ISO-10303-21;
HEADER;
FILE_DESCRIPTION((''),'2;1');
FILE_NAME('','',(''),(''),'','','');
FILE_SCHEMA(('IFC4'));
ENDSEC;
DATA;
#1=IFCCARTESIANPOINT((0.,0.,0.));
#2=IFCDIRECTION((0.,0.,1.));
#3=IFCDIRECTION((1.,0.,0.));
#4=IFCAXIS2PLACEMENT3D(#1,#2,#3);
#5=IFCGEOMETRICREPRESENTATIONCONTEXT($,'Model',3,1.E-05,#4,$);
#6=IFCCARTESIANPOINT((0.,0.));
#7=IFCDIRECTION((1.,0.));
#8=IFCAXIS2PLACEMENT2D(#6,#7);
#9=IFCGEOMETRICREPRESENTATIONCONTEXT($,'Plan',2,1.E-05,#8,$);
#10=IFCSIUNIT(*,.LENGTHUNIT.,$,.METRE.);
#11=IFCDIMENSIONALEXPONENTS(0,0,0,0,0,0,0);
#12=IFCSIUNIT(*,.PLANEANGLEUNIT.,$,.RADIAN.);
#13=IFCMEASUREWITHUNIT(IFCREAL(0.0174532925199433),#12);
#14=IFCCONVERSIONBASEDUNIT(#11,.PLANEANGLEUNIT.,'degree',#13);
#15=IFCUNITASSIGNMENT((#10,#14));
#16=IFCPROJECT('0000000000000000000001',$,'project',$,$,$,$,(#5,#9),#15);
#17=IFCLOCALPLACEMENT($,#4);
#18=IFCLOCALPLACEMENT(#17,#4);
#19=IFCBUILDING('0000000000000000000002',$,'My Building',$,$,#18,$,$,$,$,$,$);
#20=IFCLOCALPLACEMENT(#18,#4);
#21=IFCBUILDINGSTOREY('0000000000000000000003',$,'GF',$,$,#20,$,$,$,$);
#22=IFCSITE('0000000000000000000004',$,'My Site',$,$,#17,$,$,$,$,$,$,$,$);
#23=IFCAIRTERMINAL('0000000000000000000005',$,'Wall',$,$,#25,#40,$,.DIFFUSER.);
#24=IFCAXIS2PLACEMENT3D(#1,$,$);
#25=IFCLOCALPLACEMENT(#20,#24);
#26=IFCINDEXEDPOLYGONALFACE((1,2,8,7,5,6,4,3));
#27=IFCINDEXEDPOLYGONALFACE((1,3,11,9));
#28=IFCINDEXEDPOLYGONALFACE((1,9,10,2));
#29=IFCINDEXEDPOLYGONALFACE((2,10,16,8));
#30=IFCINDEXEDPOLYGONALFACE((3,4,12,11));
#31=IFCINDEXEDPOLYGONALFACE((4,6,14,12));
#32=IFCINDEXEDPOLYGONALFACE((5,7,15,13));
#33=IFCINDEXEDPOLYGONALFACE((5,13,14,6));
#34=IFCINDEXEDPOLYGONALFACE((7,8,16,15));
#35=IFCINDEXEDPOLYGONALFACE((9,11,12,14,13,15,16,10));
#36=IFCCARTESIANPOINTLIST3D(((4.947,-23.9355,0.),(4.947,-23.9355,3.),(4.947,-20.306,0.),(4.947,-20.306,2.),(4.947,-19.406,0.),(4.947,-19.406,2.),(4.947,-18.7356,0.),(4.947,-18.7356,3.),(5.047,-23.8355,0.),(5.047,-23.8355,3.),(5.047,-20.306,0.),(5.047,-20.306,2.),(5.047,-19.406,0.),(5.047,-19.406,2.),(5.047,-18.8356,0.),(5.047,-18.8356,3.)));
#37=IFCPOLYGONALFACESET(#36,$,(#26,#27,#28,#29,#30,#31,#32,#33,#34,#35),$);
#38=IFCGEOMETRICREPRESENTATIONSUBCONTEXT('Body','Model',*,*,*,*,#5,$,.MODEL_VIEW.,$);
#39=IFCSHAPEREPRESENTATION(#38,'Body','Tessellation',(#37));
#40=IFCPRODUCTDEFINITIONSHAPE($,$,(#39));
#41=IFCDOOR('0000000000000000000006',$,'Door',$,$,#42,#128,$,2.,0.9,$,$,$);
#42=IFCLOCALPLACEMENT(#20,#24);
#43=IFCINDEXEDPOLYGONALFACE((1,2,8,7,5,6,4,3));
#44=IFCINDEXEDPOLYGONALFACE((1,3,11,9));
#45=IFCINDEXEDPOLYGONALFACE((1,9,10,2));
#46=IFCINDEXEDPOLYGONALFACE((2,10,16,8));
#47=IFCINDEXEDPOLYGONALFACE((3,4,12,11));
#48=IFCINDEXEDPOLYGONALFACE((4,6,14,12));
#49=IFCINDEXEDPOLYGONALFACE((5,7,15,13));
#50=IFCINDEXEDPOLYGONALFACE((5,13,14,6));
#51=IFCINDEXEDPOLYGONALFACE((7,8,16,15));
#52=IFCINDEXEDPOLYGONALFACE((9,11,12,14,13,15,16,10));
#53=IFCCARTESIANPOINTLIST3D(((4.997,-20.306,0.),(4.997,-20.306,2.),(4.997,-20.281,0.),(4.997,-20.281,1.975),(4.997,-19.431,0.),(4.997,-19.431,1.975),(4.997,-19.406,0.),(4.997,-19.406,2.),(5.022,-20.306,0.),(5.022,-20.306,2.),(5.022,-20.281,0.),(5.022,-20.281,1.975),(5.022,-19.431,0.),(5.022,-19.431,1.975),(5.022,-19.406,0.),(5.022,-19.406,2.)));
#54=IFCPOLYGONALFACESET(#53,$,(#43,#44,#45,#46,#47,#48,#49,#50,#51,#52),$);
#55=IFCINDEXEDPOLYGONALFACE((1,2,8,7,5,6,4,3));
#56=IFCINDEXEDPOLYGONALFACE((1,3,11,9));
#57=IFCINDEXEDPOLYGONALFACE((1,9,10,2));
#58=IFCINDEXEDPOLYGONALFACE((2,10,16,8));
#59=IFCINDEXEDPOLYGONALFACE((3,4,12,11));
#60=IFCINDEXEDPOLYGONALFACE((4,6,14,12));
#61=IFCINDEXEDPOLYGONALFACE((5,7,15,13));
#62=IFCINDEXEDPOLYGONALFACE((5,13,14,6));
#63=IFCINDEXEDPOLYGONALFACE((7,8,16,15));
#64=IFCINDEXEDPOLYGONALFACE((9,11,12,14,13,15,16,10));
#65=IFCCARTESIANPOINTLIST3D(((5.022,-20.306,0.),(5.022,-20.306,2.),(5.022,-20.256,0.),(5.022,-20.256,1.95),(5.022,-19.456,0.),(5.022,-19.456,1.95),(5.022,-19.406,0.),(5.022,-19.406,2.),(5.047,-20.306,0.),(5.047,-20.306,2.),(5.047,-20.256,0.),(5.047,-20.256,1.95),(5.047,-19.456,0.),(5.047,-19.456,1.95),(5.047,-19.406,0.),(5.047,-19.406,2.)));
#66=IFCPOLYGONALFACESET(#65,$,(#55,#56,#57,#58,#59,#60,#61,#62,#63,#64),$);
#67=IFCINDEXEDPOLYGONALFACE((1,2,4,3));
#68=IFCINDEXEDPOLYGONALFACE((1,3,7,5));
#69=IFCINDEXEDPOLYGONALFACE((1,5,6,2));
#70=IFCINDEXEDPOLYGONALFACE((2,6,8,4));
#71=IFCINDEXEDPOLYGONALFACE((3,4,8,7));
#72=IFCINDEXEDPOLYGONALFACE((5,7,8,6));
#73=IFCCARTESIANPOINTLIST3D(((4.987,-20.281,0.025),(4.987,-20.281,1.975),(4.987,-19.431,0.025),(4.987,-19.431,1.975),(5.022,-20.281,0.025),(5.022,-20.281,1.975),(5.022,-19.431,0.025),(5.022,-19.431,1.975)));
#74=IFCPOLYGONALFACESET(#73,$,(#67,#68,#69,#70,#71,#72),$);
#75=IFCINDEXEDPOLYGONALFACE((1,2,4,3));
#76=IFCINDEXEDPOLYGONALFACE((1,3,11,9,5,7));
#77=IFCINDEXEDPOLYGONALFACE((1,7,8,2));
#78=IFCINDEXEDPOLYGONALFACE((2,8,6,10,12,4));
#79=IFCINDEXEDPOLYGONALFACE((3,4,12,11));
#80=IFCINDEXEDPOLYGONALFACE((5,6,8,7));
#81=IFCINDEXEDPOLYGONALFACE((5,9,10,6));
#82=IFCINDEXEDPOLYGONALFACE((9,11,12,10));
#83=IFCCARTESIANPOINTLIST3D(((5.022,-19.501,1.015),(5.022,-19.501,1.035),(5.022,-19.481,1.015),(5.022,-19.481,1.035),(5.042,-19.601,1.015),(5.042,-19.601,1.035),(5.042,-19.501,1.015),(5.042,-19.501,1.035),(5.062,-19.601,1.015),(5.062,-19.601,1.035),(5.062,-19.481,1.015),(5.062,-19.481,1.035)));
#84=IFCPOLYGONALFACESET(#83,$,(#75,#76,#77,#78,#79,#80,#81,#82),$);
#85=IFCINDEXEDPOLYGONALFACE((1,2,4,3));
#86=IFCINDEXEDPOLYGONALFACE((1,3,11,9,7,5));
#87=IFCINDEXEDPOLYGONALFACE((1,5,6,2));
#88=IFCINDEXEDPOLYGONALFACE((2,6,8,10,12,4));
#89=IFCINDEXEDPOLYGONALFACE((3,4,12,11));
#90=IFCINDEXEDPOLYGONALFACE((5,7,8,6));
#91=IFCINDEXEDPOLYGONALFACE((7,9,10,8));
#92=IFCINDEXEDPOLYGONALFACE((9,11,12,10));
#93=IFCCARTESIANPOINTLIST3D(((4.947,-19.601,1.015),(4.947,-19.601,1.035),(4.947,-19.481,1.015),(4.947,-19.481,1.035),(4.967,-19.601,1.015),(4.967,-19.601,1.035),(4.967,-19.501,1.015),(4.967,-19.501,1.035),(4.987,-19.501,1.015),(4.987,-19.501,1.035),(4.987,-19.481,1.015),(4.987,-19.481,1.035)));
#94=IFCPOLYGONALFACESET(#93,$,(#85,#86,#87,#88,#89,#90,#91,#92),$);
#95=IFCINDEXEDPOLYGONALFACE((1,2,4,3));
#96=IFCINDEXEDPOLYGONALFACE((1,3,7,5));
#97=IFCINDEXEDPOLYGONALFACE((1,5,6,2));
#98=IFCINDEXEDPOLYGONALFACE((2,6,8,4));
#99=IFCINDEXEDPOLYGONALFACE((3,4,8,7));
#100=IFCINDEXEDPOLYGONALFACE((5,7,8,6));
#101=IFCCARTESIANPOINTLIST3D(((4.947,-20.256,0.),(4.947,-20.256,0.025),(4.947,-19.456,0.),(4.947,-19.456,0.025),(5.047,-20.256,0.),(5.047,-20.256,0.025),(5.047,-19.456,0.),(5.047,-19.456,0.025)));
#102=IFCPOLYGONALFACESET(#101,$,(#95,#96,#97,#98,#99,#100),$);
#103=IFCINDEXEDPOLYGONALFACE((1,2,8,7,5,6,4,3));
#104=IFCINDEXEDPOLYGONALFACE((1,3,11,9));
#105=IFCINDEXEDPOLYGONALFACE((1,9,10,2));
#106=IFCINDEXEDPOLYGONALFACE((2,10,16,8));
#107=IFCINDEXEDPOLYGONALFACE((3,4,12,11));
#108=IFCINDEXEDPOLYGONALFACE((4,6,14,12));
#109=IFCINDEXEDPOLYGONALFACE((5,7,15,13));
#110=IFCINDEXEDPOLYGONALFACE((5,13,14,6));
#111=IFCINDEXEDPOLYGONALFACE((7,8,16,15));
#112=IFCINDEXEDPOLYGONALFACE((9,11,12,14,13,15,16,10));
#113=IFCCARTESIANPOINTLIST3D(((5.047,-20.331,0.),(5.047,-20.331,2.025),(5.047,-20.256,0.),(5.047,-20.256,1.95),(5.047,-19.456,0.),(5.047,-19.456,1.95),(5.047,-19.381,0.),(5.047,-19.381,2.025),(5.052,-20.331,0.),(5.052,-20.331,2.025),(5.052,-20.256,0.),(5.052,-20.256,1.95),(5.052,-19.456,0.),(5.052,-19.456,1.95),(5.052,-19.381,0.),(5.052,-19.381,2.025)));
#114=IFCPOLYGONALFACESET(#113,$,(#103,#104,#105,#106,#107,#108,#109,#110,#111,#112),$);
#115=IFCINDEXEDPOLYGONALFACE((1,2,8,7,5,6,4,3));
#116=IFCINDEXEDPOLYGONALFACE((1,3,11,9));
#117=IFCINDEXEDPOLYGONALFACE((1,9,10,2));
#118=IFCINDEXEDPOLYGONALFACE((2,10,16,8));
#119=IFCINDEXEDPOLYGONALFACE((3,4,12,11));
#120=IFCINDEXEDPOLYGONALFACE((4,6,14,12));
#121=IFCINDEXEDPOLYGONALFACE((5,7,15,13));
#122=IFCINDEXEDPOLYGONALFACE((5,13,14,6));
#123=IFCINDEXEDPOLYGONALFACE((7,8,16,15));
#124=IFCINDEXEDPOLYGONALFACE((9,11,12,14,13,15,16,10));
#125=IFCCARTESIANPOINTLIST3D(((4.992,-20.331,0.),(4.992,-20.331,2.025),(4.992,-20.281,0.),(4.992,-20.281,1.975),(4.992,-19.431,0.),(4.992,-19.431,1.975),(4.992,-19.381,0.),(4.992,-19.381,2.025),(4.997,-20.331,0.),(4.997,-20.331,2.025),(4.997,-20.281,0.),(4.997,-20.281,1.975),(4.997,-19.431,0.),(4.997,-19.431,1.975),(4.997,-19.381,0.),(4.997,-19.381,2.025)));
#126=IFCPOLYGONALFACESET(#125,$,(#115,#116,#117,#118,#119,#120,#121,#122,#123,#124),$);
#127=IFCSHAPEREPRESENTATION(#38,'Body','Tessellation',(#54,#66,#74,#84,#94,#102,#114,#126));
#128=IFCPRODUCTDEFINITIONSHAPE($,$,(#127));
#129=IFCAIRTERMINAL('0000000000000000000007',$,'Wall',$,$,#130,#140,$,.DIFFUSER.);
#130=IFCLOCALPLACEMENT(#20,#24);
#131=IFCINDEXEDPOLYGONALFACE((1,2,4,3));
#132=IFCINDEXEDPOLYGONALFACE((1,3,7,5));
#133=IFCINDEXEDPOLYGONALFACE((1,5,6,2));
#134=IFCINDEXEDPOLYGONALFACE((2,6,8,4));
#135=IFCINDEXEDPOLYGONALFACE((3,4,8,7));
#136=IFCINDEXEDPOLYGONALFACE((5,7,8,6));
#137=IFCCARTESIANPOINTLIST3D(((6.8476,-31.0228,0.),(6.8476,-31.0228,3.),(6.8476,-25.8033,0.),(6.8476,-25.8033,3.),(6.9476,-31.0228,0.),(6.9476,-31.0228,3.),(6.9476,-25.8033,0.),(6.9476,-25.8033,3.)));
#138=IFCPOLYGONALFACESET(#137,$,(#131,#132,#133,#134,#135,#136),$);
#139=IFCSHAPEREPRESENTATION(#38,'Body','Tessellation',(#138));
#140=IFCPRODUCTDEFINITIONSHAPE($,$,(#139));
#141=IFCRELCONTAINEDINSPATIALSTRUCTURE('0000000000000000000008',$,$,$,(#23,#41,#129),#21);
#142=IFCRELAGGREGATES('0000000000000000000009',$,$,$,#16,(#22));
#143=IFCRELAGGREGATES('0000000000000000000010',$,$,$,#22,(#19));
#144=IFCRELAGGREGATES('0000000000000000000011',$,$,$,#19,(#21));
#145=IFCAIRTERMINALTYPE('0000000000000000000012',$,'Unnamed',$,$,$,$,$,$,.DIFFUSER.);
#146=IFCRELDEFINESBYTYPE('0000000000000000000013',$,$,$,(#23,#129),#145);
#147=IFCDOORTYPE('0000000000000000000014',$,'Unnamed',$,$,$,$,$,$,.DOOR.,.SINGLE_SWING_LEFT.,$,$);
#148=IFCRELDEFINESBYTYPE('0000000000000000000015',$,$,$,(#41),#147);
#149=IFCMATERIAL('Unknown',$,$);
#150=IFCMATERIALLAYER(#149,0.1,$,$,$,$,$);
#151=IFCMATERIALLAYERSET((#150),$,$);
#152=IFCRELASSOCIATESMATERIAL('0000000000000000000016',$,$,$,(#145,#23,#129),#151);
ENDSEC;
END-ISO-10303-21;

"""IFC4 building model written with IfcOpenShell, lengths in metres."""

from ifc_helpers import new_model, entity, si_unit, converted_unit, frame, origin_with_axes, origin_2d_with_axis, place, context, subcontext, project, spatial, line, indexed_curve, outline, extrude, shape, source, transform, mapped, material, layer, layer_set, layer_usage, type_object, type_shapes, element, fill, save


model = new_model("IFC4")

# Units and contexts
model_context = context("Model", 3, precision=1e-05, world=origin_with_axes())
plan_context = context("Plan", 2, precision=1e-05, world=origin_2d_with_axis())
body_context_1 = subcontext(model_context, "Body", "Model", "MODEL_VIEW")
body_context_2 = subcontext(plan_context, "Body", "Plan", "PLAN_VIEW")
ifc_project = project(units=[si_unit("LENGTHUNIT", "METRE"), converted_unit("PLANEANGLEUNIT", "degree", entity("IfcReal", 0.0174532925199433), si_unit("PLANEANGLEUNIT", "RADIAN"), dimensions=[0, 0, 0, 0, 0, 0, 0])], contexts=[model_context, plan_context])

# Site, building, storey
site_placement = place(None, origin_with_axes())
site = spatial("IfcSite", under=ifc_project, at=site_placement, Name="My Site")
building_placement = place(site_placement, origin_with_axes())
building = spatial("IfcBuilding", under=site, at=building_placement, Name="My Building")
storey_placement = place(building_placement, origin_with_axes())
storey = spatial("IfcBuildingStorey", under=building, at=storey_placement, Name="GF")

# Shared definitions
ifc_material = material(Name="Unknown")
ifc_layer = layer(ifc_material, 0.1)
ifc_layer_set = layer_set([ifc_layer])
air_terminal_type = type_object("IfcAirTerminalType", Name="Unnamed", PredefinedType="DIFFUSER", material=ifc_layer_set)

# Shared definitions
shared_shape_1 = source(origin_with_axes(), body_context_1, "Body", "SweptSolid", [
    extrude(outline(indexed_curve([(0.0, 0.0), (0.9, 0.0), (0.9, 2.0), (0.0, 2.0)], segments=[line(1, 2, 3, 4, 1)])), frame((0.0, -0.6, 0.0), z_axis=(0.0, -1.0, 0.0), x_axis=(1.0, 0.0, 0.0)), (0.0, 0.0, -1.0), 1.2),
])
door_type = type_object("IfcDoorType", Name="Unnamed", OperationType="SINGLE_SWING_LEFT", PredefinedType="DOOR")
shared_shape_2 = source(origin_with_axes(), body_context_1, "Body", "SweptSolid", [
    extrude(outline(indexed_curve([(0.0, 0.0), (0.0, 2.0), (0.9, 2.0), (0.9, 0.0), (0.875, 0.0), (0.875, 1.975), (0.025, 1.975), (0.025, 0.0)], segments=[line(1, 2, 3, 4, 5, 6, 7, 8, 1)])), frame((0.0, 0.025, 0.0), z_axis=(0.0, -1.0, 0.0), x_axis=(1.0, 0.0, 0.0)), (0.0, 0.0, -1.0), 0.025),
    extrude(outline(indexed_curve([(0.0, 0.0), (0.0, 2.0), (0.9, 2.0), (0.9, 0.0), (0.85, 0.0), (0.85, 1.95), (0.05, 1.95), (0.05, 0.0)], segments=[line(1, 2, 3, 4, 5, 6, 7, 8, 1)])), frame((0.0, 0.0, 0.0), z_axis=(0.0, -1.0, 0.0), x_axis=(1.0, 0.0, 0.0)), (0.0, 0.0, -1.0), 0.025),
    extrude(outline(indexed_curve([(0.0, 0.0), (0.85, 0.0), (0.85, 0.035), (0.0, 0.035)], segments=[line(1, 2, 3, 4, 1)])), frame((0.025, 0.025, 0.025), z_axis=(0.0, 0.0, 1.0), x_axis=(1.0, 0.0, 0.0)), (0.0, 0.0, 1.0), 1.95),
    extrude(outline(indexed_curve([(0.0, 0.0), (0.0, -0.04), (-0.12, -0.04), (-0.12, -0.02), (-0.02, -0.02), (-0.02, 0.0)], segments=[line(1, 2, 3, 4, 5, 6, 1)])), frame((0.825, 0.025, 1.015), z_axis=(0.0, 0.0, 1.0), x_axis=(1.0, 0.0, 0.0)), (0.0, 0.0, 1.0), 0.02),
    extrude(outline(indexed_curve([(0.0, 0.0), (0.0, 0.04), (-0.12, 0.04), (-0.12, 0.02), (-0.02, 0.02), (-0.02, 0.0)], segments=[line(1, 2, 3, 4, 5, 6, 1)])), frame((0.825, 0.06, 1.015), z_axis=(0.0, 0.0, 1.0), x_axis=(1.0, 0.0, 0.0)), (0.0, 0.0, 1.0), 0.02),
    extrude(outline(indexed_curve([(0.0, 0.0), (0.8, 0.0), (0.8, 0.1), (0.0, 0.1)], segments=[line(1, 2, 3, 4, 1)])), frame((0.05, 0.0, 0.0), z_axis=(0.0, 0.0, 1.0), x_axis=(1.0, 0.0, 0.0)), (0.0, 0.0, 1.0), 0.025),
    extrude(outline(indexed_curve([(0.0, 0.0), (0.0, 2.025), (0.95, 2.025), (0.95, 0.0), (0.875, 0.0), (0.875, 1.95), (0.075, 1.95), (0.075, 0.0)], segments=[line(1, 2, 3, 4, 5, 6, 7, 8, 1)])), frame((-0.025, -0.005, 0.0), z_axis=(0.0, -1.0, 0.0), x_axis=(1.0, 0.0, 0.0)), (0.0, 0.0, -1.0), 0.005),
    extrude(outline(indexed_curve([(0.0, 0.0), (0.0, 2.025), (0.95, 2.025), (0.95, 0.0), (0.9, 0.0), (0.9, 1.975), (0.05, 1.975), (0.05, 0.0)], segments=[line(1, 2, 3, 4, 5, 6, 7, 8, 1)])), frame((-0.025, 0.05, 0.0), z_axis=(0.0, -1.0, 0.0), x_axis=(1.0, 0.0, 0.0)), (0.0, 0.0, -1.0), 0.005),
])
shared_shape_3 = source(origin_with_axes(), body_context_2, "Body", "Curve2D", [
    entity("IfcIndexedPolyCurve", entity("IfcCartesianPointList2D", [[0.0, 0.0], [0.0, 0.05], [0.025, 0.05], [0.025, 0.025], [0.05, 0.025], [0.05, 0.0]]), [entity("IfcLineIndex", [1, 2, 3, 4, 5, 6, 1])]),
    entity("IfcIndexedPolyCurve", entity("IfcCartesianPointList2D", [[0.9, 0.0], [0.9, 0.05], [0.875, 0.05], [0.875, 0.025], [0.85, 0.025], [0.85, 0.0]]), [entity("IfcLineIndex", [1, 2, 3, 4, 5, 6, 1])]),
    entity("IfcTrimmedCurve", entity("IfcEllipse", entity("IfcAxis2Placement2D", entity("IfcCartesianPoint", [0.06, 0.05]), entity("IfcDirection", [1.0, 0.0])), 0.815, 0.85), [entity("IfcCartesianPoint", [0.875, 0.05])], [entity("IfcCartesianPoint", [0.06, 0.9])], True, "CARTESIAN"),
    entity("IfcIndexedPolyCurve", entity("IfcCartesianPointList2D", [[0.025, 0.05], [0.06, 0.05], [0.06, 0.9], [0.025, 0.9]]), [entity("IfcLineIndex", [1, 2, 3, 4, 1])]),
])
type_shapes(door_type, [shared_shape_2, shared_shape_3])

# Air terminal, opening, door
ifc_layer_usage_1 = layer_usage(ifc_layer_set, "AXIS2", "POSITIVE", 0.0)
air_terminal_1_placement = place(storey_placement, frame((5.047, -23.8355, 0.0), z_axis=(0.0, 0.0, 1.0), x_axis=(0.0, 1.0, 0.0)))
air_terminal_1 = element("IfcAirTerminal", 1, at=air_terminal_1_placement, inside=storey, type_object=air_terminal_type, material=ifc_layer_usage_1, Name="Wall", PredefinedType="DIFFUSER", context=body_context_1, shape_type="SweptSolid", body=[
    extrude(outline(indexed_curve([(0.0, 0.0), (-0.1, 0.1), (5.1, 0.1), (5.0, 0.0)], segments=[line(1, 2, 3, 4, 1)])), origin_with_axes(), (0.0, 0.0, 1.0), 3.0),
])
opening_1_placement = place(air_terminal_1_placement, frame((3.5295, 0.0, 0.0), z_axis=(0.0, 0.0, 1.0), x_axis=(1.0, 0.0, 0.0)))
opening_1 = element("IfcOpeningElement", 2, at=opening_1_placement, cuts=air_terminal_1, PredefinedType="OPENING", context=body_context_1, shape_type="MappedRepresentation", body=[
    mapped(shared_shape_1, transform((0.0, 0.0, 0.0), x_axis=(1.0, 0.0, 0.0), y_axis=(0.0, 1.0, 0.0), z_axis=(0.0, 0.0, 1.0), scale=1.0)),
])
door_1_placement = place(opening_1_placement, frame((0.0, 0.0, 0.0), z_axis=(0.0, 0.0, 1.0), x_axis=(1.0, 0.0, 0.0)))
door_1 = element("IfcDoor", 3, at=door_1_placement, inside=storey, type_object=door_type, Name="Door", OverallHeight=2.0, OverallWidth=0.9, shapes=[
    shape(body_context_1, "Body", "MappedRepresentation", [mapped(shared_shape_2, transform((0.0, 0.0, 0.0), x_axis=(1.0, 0.0, 0.0), y_axis=(0.0, 1.0, 0.0), z_axis=(0.0, 0.0, 1.0), scale=1.0))]),
    shape(body_context_2, "Body", "MappedRepresentation", [mapped(shared_shape_3, transform((0.0, 0.0, 0.0), x_axis=(1.0, 0.0, 0.0), y_axis=(0.0, 1.0, 0.0), z_axis=(0.0, 0.0, 1.0), scale=1.0))]),
])
fill(opening_1, door_1)

# Air terminal
ifc_layer_usage_2 = layer_usage(ifc_layer_set, "AXIS2", "POSITIVE", 0.0)
air_terminal_2_placement = place(storey_placement, frame((6.8476, -25.8033, 0.0), z_axis=(0.0, 0.0, 1.0), x_axis=(0.0, -1.0, 0.0)))
element("IfcAirTerminal", 4, at=air_terminal_2_placement, inside=storey, type_object=air_terminal_type, material=ifc_layer_usage_2, Name="Wall", PredefinedType="DIFFUSER", context=body_context_1, shape_type="SweptSolid", body=[
    extrude(outline(indexed_curve([(0.0, 0.0), (0.0, 0.1), (5.2195, 0.1), (5.2195, 0.0)], segments=[line(1, 2, 3, 4, 1)])), origin_with_axes(), (0.0, 0.0, 1.0), 3.0),
])

save(model, "model.ifc")
